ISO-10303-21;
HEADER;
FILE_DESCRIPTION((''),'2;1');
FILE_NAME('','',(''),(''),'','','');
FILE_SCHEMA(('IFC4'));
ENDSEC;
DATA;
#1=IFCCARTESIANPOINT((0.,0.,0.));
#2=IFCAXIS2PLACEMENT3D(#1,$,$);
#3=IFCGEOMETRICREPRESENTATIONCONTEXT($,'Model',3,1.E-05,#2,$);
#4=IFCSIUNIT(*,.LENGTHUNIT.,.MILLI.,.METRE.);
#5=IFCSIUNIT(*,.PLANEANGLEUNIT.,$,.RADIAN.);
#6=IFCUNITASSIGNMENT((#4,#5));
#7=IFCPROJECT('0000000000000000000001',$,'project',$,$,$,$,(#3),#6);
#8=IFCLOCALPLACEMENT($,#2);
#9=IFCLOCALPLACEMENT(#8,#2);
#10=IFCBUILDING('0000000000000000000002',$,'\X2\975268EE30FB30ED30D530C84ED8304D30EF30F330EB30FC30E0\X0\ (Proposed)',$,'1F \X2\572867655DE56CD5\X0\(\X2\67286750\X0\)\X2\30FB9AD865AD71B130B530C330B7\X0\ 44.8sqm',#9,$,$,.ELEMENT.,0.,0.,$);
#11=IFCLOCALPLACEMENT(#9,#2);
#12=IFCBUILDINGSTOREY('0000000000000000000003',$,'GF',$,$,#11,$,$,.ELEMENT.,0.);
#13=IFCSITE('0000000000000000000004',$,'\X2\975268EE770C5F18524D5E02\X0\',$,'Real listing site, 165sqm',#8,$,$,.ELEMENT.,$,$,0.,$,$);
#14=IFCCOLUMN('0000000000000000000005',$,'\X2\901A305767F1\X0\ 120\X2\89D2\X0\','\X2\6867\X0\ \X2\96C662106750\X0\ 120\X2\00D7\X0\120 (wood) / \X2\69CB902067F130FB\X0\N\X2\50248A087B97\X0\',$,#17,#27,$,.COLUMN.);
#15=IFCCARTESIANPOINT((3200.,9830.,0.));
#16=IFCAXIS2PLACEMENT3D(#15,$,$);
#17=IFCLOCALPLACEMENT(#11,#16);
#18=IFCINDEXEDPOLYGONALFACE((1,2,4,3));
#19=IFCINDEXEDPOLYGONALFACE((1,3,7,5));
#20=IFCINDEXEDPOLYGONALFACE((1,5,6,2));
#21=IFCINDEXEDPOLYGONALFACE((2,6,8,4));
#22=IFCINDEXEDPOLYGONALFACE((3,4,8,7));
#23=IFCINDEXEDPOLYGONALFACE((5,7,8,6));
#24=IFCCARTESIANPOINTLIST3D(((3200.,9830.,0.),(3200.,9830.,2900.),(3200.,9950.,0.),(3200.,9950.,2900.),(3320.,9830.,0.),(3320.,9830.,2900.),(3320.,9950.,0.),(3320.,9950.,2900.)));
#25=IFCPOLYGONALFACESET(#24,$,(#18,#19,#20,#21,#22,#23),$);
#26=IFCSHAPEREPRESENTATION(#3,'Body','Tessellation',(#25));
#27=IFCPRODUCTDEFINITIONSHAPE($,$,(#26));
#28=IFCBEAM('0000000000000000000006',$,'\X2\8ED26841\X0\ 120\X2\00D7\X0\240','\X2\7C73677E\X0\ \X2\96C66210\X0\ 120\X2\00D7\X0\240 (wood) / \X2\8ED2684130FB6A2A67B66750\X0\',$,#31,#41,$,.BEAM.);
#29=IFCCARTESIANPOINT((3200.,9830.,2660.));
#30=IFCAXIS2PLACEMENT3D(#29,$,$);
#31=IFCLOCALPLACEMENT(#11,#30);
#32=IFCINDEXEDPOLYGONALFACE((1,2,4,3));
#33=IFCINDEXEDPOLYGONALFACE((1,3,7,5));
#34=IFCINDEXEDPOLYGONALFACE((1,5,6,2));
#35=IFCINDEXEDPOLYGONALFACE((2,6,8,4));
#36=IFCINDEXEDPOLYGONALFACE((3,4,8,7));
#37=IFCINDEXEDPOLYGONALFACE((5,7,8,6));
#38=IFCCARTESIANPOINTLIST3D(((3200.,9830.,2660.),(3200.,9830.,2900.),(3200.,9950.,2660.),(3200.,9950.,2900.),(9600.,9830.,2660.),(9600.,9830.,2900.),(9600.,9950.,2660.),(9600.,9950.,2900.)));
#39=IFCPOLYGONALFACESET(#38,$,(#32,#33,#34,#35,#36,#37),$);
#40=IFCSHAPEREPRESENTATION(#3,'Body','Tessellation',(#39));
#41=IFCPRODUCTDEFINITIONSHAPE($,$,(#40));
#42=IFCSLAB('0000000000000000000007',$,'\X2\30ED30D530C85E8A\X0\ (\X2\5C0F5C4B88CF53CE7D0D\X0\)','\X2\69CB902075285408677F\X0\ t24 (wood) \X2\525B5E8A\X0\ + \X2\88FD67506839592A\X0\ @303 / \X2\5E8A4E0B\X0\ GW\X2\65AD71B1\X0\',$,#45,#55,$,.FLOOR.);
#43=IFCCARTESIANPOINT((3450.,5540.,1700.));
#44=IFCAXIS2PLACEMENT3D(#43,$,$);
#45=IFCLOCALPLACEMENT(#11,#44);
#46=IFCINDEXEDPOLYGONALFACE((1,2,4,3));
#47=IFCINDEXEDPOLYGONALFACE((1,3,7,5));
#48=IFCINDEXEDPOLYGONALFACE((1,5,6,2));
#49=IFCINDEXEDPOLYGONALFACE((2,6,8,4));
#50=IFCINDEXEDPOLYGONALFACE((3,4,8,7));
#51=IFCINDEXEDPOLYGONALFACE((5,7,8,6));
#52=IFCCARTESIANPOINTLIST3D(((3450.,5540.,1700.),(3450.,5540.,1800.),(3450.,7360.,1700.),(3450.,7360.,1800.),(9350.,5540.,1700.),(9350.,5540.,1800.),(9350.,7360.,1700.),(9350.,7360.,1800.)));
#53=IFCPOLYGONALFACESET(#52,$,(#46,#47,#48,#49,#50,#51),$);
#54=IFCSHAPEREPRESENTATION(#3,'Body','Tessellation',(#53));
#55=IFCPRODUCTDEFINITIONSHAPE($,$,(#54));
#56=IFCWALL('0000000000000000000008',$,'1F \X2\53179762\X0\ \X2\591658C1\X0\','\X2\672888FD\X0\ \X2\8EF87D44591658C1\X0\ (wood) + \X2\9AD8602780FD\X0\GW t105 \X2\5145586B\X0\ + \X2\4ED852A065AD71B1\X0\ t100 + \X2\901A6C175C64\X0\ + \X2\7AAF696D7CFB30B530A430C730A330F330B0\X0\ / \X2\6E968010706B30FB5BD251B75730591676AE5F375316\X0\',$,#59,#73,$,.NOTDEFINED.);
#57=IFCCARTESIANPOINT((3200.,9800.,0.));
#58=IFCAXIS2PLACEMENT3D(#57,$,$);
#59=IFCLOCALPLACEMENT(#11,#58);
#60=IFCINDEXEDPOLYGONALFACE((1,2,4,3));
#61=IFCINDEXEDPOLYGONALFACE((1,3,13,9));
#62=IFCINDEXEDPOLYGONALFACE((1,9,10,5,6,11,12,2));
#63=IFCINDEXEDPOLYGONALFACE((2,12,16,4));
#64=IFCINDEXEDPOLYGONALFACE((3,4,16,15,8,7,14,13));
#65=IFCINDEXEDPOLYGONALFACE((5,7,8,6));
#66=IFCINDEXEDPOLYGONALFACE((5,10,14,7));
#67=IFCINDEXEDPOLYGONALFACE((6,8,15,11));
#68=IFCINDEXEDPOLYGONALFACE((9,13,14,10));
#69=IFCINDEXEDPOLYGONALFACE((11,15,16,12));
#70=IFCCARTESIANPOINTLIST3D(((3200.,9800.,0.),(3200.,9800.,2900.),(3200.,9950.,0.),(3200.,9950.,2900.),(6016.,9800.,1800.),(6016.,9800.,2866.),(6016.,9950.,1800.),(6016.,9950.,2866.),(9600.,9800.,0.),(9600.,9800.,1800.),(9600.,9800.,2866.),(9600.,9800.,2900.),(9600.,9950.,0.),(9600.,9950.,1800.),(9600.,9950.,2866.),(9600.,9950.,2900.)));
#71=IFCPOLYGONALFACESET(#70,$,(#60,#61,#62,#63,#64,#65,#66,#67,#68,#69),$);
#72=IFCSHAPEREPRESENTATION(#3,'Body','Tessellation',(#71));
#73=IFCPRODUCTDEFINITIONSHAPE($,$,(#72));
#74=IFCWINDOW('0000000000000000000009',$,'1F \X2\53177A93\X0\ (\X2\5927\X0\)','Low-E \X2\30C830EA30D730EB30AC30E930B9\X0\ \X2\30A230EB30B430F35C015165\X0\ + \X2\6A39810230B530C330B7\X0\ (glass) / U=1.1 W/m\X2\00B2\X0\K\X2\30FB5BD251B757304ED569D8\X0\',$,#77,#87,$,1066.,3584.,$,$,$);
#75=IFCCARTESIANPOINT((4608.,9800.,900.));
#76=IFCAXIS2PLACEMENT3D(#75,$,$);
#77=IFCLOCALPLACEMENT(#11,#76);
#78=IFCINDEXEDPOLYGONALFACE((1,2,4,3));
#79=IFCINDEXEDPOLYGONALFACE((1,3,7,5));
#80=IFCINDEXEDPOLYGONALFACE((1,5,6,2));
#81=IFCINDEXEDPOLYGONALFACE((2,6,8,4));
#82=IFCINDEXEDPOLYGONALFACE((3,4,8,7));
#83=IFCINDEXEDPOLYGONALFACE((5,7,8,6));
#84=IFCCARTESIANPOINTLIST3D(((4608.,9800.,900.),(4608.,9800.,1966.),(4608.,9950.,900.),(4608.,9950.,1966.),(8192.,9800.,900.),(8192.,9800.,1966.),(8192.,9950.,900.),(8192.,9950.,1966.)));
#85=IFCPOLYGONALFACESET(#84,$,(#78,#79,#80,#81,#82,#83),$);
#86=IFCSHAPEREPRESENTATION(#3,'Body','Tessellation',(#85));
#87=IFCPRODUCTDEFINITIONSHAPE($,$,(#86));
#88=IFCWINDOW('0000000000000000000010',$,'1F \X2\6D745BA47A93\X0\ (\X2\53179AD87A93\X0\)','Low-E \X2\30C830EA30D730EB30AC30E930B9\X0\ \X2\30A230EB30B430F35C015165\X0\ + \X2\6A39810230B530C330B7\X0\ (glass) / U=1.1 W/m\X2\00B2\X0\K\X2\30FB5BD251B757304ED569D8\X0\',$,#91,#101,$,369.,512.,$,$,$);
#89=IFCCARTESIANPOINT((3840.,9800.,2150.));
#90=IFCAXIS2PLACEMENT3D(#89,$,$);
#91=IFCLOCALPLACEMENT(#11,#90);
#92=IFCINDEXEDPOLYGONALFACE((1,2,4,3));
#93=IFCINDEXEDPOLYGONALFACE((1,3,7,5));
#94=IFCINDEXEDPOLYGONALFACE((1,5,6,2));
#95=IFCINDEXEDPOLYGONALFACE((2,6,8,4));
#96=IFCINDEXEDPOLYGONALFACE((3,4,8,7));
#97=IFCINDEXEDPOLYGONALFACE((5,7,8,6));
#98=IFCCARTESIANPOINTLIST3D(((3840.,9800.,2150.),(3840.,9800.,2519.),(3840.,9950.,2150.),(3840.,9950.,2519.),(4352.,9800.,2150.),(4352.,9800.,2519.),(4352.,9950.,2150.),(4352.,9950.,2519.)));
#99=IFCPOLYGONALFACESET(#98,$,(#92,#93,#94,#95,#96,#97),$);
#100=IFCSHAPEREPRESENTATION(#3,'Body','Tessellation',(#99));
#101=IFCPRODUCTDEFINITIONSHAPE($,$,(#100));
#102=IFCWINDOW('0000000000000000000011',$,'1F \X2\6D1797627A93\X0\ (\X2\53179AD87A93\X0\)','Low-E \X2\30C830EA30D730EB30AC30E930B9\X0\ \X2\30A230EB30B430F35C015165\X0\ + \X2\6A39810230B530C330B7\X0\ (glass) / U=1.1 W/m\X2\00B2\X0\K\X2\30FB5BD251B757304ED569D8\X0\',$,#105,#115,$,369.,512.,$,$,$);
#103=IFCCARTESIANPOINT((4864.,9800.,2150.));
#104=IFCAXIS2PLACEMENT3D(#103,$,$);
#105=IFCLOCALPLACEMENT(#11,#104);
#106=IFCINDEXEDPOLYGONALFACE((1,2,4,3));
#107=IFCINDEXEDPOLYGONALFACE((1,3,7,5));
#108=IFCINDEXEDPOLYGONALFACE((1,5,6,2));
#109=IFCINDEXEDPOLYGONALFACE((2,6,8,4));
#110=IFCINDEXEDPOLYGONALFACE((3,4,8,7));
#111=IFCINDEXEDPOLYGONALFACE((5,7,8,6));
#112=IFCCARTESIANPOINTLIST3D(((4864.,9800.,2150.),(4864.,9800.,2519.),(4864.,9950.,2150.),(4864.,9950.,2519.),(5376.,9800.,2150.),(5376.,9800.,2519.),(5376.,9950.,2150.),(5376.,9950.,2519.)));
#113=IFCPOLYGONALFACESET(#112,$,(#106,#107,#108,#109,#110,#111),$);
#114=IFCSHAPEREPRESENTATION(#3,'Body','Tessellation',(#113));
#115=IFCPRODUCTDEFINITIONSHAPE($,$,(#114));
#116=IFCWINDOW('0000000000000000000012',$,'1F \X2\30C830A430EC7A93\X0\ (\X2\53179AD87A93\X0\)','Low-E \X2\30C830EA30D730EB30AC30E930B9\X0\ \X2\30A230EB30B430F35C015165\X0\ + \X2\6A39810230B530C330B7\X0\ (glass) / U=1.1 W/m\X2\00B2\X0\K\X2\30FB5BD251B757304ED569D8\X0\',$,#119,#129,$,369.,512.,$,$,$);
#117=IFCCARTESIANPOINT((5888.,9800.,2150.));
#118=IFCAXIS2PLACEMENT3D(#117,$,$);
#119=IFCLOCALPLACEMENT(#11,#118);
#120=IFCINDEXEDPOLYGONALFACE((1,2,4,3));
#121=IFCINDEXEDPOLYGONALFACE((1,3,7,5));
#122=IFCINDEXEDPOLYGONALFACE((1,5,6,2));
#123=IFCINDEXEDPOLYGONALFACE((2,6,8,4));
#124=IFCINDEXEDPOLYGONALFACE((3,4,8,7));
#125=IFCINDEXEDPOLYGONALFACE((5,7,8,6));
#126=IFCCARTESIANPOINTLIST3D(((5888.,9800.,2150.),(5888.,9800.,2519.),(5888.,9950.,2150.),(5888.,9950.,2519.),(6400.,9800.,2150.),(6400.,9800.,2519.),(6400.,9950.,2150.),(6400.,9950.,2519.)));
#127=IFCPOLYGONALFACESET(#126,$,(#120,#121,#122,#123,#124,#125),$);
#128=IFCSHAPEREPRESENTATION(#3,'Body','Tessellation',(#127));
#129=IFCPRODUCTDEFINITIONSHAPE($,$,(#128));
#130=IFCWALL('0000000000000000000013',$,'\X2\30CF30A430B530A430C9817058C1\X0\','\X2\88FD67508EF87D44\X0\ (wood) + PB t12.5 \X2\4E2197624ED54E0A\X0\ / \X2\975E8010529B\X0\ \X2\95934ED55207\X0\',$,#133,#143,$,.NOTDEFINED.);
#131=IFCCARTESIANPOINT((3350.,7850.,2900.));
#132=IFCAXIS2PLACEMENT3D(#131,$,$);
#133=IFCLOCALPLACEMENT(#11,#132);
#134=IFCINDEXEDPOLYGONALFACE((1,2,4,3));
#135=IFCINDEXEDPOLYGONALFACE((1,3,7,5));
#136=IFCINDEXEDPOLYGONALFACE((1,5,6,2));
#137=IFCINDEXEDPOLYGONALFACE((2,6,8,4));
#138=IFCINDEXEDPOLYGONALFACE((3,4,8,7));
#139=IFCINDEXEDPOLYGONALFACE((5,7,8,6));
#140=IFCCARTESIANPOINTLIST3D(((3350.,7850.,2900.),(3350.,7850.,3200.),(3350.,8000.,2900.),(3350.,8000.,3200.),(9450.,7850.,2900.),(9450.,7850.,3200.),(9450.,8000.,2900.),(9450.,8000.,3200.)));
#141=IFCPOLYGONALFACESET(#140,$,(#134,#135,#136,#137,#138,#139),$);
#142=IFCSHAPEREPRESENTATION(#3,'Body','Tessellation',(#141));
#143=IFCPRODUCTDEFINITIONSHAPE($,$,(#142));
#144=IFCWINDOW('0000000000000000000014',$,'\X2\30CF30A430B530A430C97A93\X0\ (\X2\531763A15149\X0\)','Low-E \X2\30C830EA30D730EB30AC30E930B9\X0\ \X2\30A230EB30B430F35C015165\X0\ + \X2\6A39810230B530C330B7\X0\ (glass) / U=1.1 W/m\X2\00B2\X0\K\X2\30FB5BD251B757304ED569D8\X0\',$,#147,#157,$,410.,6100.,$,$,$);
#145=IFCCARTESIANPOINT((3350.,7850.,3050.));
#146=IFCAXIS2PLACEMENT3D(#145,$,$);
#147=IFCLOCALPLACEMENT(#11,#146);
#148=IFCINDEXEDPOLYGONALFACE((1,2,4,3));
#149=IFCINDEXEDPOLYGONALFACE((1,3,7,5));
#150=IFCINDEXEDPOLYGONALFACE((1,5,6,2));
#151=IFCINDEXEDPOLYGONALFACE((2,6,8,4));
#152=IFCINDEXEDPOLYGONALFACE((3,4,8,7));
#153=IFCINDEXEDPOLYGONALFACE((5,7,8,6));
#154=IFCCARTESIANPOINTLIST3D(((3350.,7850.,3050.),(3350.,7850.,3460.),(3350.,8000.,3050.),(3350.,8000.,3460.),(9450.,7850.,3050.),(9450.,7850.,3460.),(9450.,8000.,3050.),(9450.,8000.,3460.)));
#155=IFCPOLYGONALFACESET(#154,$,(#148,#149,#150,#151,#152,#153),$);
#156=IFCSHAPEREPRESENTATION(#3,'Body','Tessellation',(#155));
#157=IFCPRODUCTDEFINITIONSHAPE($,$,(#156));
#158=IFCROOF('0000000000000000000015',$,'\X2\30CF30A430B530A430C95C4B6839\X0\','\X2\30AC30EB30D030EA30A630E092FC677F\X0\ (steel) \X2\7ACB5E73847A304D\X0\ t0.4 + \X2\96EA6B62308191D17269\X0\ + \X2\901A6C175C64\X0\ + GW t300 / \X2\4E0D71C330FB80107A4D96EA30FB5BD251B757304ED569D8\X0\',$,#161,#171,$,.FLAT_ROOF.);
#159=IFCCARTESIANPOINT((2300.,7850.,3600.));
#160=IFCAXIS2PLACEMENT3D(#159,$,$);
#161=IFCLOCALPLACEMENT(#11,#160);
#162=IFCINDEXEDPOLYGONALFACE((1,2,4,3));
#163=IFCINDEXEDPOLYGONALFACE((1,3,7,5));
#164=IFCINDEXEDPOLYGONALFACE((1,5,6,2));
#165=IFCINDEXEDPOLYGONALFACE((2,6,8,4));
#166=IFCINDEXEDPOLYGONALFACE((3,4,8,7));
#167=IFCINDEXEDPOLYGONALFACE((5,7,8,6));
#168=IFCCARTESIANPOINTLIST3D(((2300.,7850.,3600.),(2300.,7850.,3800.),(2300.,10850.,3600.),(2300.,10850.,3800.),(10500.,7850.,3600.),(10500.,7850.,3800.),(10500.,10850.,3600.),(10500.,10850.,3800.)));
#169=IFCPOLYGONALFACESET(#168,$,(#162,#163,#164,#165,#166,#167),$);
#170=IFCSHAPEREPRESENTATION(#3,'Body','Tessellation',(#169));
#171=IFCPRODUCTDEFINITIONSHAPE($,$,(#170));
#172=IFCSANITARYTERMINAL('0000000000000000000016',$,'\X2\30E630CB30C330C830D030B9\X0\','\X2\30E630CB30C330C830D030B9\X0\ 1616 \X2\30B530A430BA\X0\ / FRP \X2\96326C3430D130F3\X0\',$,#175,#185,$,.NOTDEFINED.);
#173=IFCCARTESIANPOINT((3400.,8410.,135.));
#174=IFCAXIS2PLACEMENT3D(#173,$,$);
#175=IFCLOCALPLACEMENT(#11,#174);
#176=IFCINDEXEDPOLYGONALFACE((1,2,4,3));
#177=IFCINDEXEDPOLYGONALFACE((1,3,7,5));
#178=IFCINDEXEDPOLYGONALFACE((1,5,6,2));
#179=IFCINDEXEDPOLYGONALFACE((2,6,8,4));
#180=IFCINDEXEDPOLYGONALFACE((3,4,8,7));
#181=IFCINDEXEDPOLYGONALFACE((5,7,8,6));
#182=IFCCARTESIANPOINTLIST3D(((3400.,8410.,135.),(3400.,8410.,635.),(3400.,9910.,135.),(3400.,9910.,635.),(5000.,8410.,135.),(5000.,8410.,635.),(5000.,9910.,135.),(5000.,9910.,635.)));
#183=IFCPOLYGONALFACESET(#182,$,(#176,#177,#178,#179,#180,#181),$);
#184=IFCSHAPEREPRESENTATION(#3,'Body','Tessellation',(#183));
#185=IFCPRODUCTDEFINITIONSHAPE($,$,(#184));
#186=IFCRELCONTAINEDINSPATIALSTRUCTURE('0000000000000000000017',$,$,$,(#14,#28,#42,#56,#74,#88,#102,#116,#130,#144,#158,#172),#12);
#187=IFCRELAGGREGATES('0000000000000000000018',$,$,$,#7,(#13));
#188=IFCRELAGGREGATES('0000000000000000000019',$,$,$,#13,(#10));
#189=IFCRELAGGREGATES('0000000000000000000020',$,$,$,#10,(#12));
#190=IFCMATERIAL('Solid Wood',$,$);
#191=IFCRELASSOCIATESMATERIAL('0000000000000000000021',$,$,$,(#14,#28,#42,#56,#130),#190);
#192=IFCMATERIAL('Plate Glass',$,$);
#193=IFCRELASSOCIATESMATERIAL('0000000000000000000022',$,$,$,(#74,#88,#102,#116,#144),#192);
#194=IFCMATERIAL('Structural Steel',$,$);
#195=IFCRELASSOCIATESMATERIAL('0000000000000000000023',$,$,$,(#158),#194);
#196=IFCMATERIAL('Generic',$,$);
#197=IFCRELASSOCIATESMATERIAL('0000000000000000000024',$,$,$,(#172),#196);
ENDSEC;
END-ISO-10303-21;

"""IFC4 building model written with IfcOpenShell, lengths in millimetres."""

from ifc_helpers import new_model, si_unit, frame, frame_2d, origin, place, context, project, spatial, rectangle, extrude, material, element, fill, save


model = new_model("IFC4")

# Units and contexts
model_context = context("Model", 3, precision=1e-05, world=origin())
ifc_project = project(units=[si_unit("LENGTHUNIT", "METRE", prefix="MILLI"), si_unit("PLANEANGLEUNIT", "RADIAN")], contexts=[model_context])

# Site, building, storey
site_placement = place(None, origin())
site = spatial("IfcSite", under=ifc_project, at=site_placement, Name="青森県弘前市", ObjectType="Real listing site, 165sqm", CompositionType="ELEMENT", RefElevation=0.0)
building_placement = place(site_placement, origin())
building = spatial("IfcBuilding", under=site, at=building_placement, Name="青森・ロフト付きワンルーム (Proposed)", ObjectType="1F 在来工法(木材)・高断熱サッシ 44.8sqm", CompositionType="ELEMENT", ElevationOfRefHeight=0.0, ElevationOfTerrain=0.0)
storey_placement = place(building_placement, origin())
storey = spatial("IfcBuildingStorey", under=building, at=storey_placement, Name="GF", CompositionType="ELEMENT", Elevation=0.0)

# Column
ifc_material_1 = material(Name="Solid Wood")
column_1_placement = place(storey_placement, frame((3200.0, 9830.0, 0.0)))
element("IfcColumn", 1, at=column_1_placement, inside=storey, material=ifc_material_1, Name="通し柱 120角", Description="桧 集成材 120×120 (wood) / 構造柱・N値計算", PredefinedType="COLUMN", context=model_context, shape_type="SweptSolid", body=[
    extrude(rectangle(XDim=120.0, YDim=120.0, at=frame_2d((60.0, 60.0))), frame((3200.0, 9830.0, 0.0)), (0.0, 0.0, 1.0), 2900.0),
])

# Beam
beam_1_placement = place(storey_placement, frame((3200.0, 9830.0, 2660.0)))
element("IfcBeam", 2, at=beam_1_placement, inside=storey, material=ifc_material_1, Name="軒桁 120×240", Description="米松 集成 120×240 (wood) / 軒桁・横架材", PredefinedType="BEAM", context=model_context, shape_type="SweptSolid", body=[
    extrude(rectangle(XDim=6400.0, YDim=120.0, at=frame_2d((3200.0, 60.0))), frame((3200.0, 9830.0, 2660.0)), (0.0, 0.0, 1.0), 240.0),
])

# Slab
slab_placement = place(storey_placement, frame((3450.0, 5540.0, 1700.0)))
element("IfcSlab", 3, at=slab_placement, inside=storey, material=ifc_material_1, Name="ロフト床 (小屋裏収納)", Description="構造用合板 t24 (wood) 剛床 + 製材根太 @303 / 床下 GW断熱", PredefinedType="FLOOR", context=model_context, shape_type="SweptSolid", body=[
    extrude(rectangle(XDim=5900.0, YDim=1820.0, at=frame_2d((2950.0, 910.0))), frame((3450.0, 5540.0, 1700.0)), (0.0, 0.0, 1.0), 100.0),
])

# Wall, openings, windows
wall_1_placement = place(storey_placement, frame((3200.0, 9800.0, 0.0)))
wall_1 = element("IfcWall", 4, at=wall_1_placement, inside=storey, material=ifc_material_1, Name="1F 北面 外壁", Description="木製 軸組外壁 (wood) + 高性能GW t105 充填 + 付加断熱 t100 + 通気層 + 窯業系サイディング / 準耐火・寒冷地外皮強化", PredefinedType="NOTDEFINED", context=model_context, shape_type="SweptSolid", body=[
    extrude(rectangle(XDim=6400.0, YDim=150.0, at=frame_2d((3200.0, 75.0))), frame((3200.0, 9800.0, 0.0)), (0.0, 0.0, 1.0), 2900.0),
])
opening_1_placement = place(storey_placement, frame((4608.0, 9800.0, 900.0)))
opening_1 = element("IfcOpeningElement", 5, at=opening_1_placement, cuts=wall_1, PredefinedType="NOTDEFINED", context=model_context, shape_type="SweptSolid", body=[
    extrude(rectangle(XDim=3584.0, YDim=150.0, at=frame_2d((1792.0, 75.0))), frame((4608.0, 9800.0, 900.0)), (0.0, 0.0, 1.0), 1066.0),
])
opening_2_placement = place(storey_placement, frame((3840.0, 9800.0, 2150.0)))
opening_2 = element("IfcOpeningElement", 6, at=opening_2_placement, cuts=wall_1, PredefinedType="NOTDEFINED", context=model_context, shape_type="SweptSolid", body=[
    extrude(rectangle(XDim=512.0, YDim=150.0, at=frame_2d((256.0, 75.0))), frame((3840.0, 9800.0, 2150.0)), (0.0, 0.0, 1.0), 369.0),
])
opening_3_placement = place(storey_placement, frame((4864.0, 9800.0, 2150.0)))
opening_3 = element("IfcOpeningElement", 7, at=opening_3_placement, cuts=wall_1, PredefinedType="NOTDEFINED", context=model_context, shape_type="SweptSolid", body=[
    extrude(rectangle(XDim=512.0, YDim=150.0, at=frame_2d((256.0, 75.0))), frame((4864.0, 9800.0, 2150.0)), (0.0, 0.0, 1.0), 369.0),
])
opening_4_placement = place(storey_placement, frame((5888.0, 9800.0, 2150.0)))
opening_4 = element("IfcOpeningElement", 8, at=opening_4_placement, cuts=wall_1, PredefinedType="NOTDEFINED", context=model_context, shape_type="SweptSolid", body=[
    extrude(rectangle(XDim=512.0, YDim=150.0, at=frame_2d((256.0, 75.0))), frame((5888.0, 9800.0, 2150.0)), (0.0, 0.0, 1.0), 369.0),
])
ifc_material_2 = material(Name="Plate Glass")
window_1_placement = place(storey_placement, frame((4608.0, 9800.0, 900.0)))
window_1 = element("IfcWindow", 9, at=window_1_placement, inside=storey, material=ifc_material_2, Name="1F 北窓 (大)", Description="Low-E トリプルガラス アルゴン封入 + 樹脂サッシ (glass) / U=1.1 W/m²K・寒冷地仕様", OverallHeight=1066.0, OverallWidth=3584.0, context=model_context, shape_type="SweptSolid", body=[
    extrude(rectangle(XDim=3584.0, YDim=150.0, at=frame_2d((1792.0, 75.0))), frame((4608.0, 9800.0, 900.0)), (0.0, 0.0, 1.0), 1066.0),
])
fill(opening_1, window_1)
window_2_placement = place(storey_placement, frame((3840.0, 9800.0, 2150.0)))
window_2 = element("IfcWindow", 10, at=window_2_placement, inside=storey, material=ifc_material_2, Name="1F 浴室窓 (北高窓)", Description="Low-E トリプルガラス アルゴン封入 + 樹脂サッシ (glass) / U=1.1 W/m²K・寒冷地仕様", OverallHeight=369.0, OverallWidth=512.0, context=model_context, shape_type="SweptSolid", body=[
    extrude(rectangle(XDim=512.0, YDim=150.0, at=frame_2d((256.0, 75.0))), frame((3840.0, 9800.0, 2150.0)), (0.0, 0.0, 1.0), 369.0),
])
fill(opening_2, window_2)
window_3_placement = place(storey_placement, frame((4864.0, 9800.0, 2150.0)))
window_3 = element("IfcWindow", 11, at=window_3_placement, inside=storey, material=ifc_material_2, Name="1F 洗面窓 (北高窓)", Description="Low-E トリプルガラス アルゴン封入 + 樹脂サッシ (glass) / U=1.1 W/m²K・寒冷地仕様", OverallHeight=369.0, OverallWidth=512.0, context=model_context, shape_type="SweptSolid", body=[
    extrude(rectangle(XDim=512.0, YDim=150.0, at=frame_2d((256.0, 75.0))), frame((4864.0, 9800.0, 2150.0)), (0.0, 0.0, 1.0), 369.0),
])
fill(opening_3, window_3)
window_4_placement = place(storey_placement, frame((5888.0, 9800.0, 2150.0)))
window_4 = element("IfcWindow", 12, at=window_4_placement, inside=storey, material=ifc_material_2, Name="1F トイレ窓 (北高窓)", Description="Low-E トリプルガラス アルゴン封入 + 樹脂サッシ (glass) / U=1.1 W/m²K・寒冷地仕様", OverallHeight=369.0, OverallWidth=512.0, context=model_context, shape_type="SweptSolid", body=[
    extrude(rectangle(XDim=512.0, YDim=150.0, at=frame_2d((256.0, 75.0))), frame((5888.0, 9800.0, 2150.0)), (0.0, 0.0, 1.0), 369.0),
])
fill(opening_4, window_4)

# Wall, opening, window
wall_2_placement = place(storey_placement, frame((3350.0, 7850.0, 2900.0)))
wall_2 = element("IfcWall", 13, at=wall_2_placement, inside=storey, material=ifc_material_1, Name="ハイサイド腰壁", Description="製材軸組 (wood) + PB t12.5 両面仕上 / 非耐力 間仕切", PredefinedType="NOTDEFINED", context=model_context, shape_type="SweptSolid", body=[
    extrude(rectangle(XDim=6100.0, YDim=150.0, at=frame_2d((3050.0, 75.0))), frame((3350.0, 7850.0, 2900.0)), (0.0, 0.0, 1.0), 700.0),
])
opening_5_placement = place(storey_placement, frame((3350.0, 7850.0, 3050.0)))
opening_5 = element("IfcOpeningElement", 14, at=opening_5_placement, cuts=wall_2, PredefinedType="NOTDEFINED", context=model_context, shape_type="SweptSolid", body=[
    extrude(rectangle(XDim=6100.0, YDim=150.0, at=frame_2d((3050.0, 75.0))), frame((3350.0, 7850.0, 3050.0)), (0.0, 0.0, 1.0), 410.0),
])
window_5_placement = place(storey_placement, frame((3350.0, 7850.0, 3050.0)))
window_5 = element("IfcWindow", 15, at=window_5_placement, inside=storey, material=ifc_material_2, Name="ハイサイド窓 (北採光)", Description="Low-E トリプルガラス アルゴン封入 + 樹脂サッシ (glass) / U=1.1 W/m²K・寒冷地仕様", OverallHeight=410.0, OverallWidth=6100.0, context=model_context, shape_type="SweptSolid", body=[
    extrude(rectangle(XDim=6100.0, YDim=150.0, at=frame_2d((3050.0, 75.0))), frame((3350.0, 7850.0, 3050.0)), (0.0, 0.0, 1.0), 410.0),
])
fill(opening_5, window_5)

# Roof
ifc_material_3 = material(Name="Structural Steel")
roof_placement = place(storey_placement, frame((2300.0, 7850.0, 3600.0)))
element("IfcRoof", 16, at=roof_placement, inside=storey, material=ifc_material_3, Name="ハイサイド屋根", Description="ガルバリウム鋼板 (steel) 立平葺き t0.4 + 雪止め金物 + 通気層 + GW t300 / 不燃・耐積雪・寒冷地仕様", PredefinedType="FLAT_ROOF", context=model_context, shape_type="SweptSolid", body=[
    extrude(rectangle(XDim=8200.0, YDim=3000.0, at=frame_2d((4100.0, 1500.0))), frame((2300.0, 7850.0, 3600.0)), (0.0, 0.0, 1.0), 200.0),
])

# Sanitary terminal
ifc_material_4 = material(Name="Generic")
sanitary_terminal_placement = place(storey_placement, frame((3400.0, 8410.0, 135.0)))
element("IfcSanitaryTerminal", 17, at=sanitary_terminal_placement, inside=storey, material=ifc_material_4, Name="ユニットバス", Description="ユニットバス 1616 サイズ / FRP 防水パン", PredefinedType="NOTDEFINED", context=model_context, shape_type="SweptSolid", body=[
    extrude(rectangle(XDim=1600.0, YDim=1500.0, at=frame_2d((800.0, 750.0))), frame((3400.0, 8410.0, 135.0)), (0.0, 0.0, 1.0), 500.0),
])

save(model, "model.ifc")
